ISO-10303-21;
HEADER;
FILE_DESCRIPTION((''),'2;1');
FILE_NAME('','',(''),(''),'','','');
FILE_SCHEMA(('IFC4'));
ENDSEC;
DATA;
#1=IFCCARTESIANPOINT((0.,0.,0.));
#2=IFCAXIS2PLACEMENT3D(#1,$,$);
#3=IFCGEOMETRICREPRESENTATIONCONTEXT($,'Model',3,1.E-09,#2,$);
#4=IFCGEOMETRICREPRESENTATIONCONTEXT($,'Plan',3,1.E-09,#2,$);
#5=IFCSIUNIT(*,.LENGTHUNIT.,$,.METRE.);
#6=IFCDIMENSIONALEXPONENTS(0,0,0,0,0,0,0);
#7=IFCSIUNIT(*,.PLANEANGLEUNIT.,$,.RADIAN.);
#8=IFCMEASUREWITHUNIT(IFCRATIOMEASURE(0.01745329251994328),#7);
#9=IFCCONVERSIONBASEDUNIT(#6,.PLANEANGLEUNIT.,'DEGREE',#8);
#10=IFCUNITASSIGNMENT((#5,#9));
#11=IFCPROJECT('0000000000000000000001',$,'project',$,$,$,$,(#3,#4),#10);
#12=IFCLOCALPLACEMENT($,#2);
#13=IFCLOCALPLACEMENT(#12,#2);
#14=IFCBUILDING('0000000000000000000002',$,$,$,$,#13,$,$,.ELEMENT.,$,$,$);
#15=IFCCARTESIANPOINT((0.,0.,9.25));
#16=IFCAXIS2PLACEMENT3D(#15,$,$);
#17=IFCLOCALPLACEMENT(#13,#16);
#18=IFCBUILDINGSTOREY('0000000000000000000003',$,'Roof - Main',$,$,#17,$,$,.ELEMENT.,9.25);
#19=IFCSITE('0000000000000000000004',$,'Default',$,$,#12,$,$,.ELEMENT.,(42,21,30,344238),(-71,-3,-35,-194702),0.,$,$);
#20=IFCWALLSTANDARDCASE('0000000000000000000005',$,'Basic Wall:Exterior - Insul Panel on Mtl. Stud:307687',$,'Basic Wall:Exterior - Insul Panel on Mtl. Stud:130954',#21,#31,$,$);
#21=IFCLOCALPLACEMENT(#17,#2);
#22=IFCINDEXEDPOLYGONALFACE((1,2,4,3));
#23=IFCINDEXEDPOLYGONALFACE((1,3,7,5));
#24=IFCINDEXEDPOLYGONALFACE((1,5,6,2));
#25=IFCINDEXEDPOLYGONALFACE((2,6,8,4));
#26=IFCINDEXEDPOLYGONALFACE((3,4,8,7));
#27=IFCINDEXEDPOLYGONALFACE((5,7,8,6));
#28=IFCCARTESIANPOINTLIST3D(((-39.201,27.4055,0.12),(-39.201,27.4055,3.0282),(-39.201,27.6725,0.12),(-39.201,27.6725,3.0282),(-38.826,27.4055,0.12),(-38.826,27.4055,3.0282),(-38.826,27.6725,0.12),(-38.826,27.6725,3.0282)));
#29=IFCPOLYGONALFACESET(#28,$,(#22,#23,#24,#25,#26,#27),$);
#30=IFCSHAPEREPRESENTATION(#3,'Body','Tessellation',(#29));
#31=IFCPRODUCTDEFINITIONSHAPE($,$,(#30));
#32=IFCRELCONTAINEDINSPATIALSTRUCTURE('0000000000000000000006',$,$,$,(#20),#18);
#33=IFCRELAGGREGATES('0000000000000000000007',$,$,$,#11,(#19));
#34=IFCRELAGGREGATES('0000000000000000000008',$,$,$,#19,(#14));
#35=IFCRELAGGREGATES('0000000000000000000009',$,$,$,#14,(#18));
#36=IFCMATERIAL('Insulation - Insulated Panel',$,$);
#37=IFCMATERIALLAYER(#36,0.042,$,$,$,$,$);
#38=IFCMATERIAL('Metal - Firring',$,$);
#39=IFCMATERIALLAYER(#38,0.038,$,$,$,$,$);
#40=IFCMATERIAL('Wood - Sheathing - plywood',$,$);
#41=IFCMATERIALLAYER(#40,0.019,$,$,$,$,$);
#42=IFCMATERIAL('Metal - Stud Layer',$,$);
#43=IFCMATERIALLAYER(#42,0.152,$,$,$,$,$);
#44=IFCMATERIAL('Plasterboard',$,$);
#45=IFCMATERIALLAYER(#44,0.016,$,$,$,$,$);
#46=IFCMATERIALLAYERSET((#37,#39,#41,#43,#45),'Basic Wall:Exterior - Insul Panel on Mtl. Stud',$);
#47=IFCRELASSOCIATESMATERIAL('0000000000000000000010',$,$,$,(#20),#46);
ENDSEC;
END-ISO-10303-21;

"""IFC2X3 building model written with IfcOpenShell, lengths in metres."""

from ifc_helpers import new_model, entity, si_unit, converted_unit, frame, frame_2d, origin, place, context, project, spatial, rectangle, extrude, material, layer, layer_set, layer_usage, element, save


model = new_model("IFC2X3")

# Units and contexts
model_context = context("Model", 3, precision=1e-09, world=origin())
plan_context = context("Plan", 3, precision=1e-09, world=origin())
ifc_project = project(units=[si_unit("LENGTHUNIT", "METRE"), converted_unit("PLANEANGLEUNIT", "DEGREE", entity("IfcRatioMeasure", 0.01745329251994328), si_unit("PLANEANGLEUNIT", "RADIAN"), dimensions=[0, 0, 0, 0, 0, 0, 0])], contexts=[model_context, plan_context])

# Site, building, storey
site_placement = place(None, origin())
site = spatial("IfcSite", under=ifc_project, at=site_placement, Name="Default", CompositionType="ELEMENT", RefLatitude=(42, 21, 30, 344238), RefLongitude=(-71, -3, -35, -194702), RefElevation=0.0)
building_placement = place(site_placement, origin())
building = spatial("IfcBuilding", under=site, at=building_placement, CompositionType="ELEMENT")
storey_placement = place(building_placement, frame((0.0, 0.0, 9.25)))
storey = spatial("IfcBuildingStorey", under=building, at=storey_placement, Name="Roof - Main", CompositionType="ELEMENT", Elevation=9.25)

# Wall
ifc_material_1 = material(Name="Insulation - Insulated Panel")
ifc_layer_1 = layer(ifc_material_1, 0.042)
ifc_material_2 = material(Name="Metal - Firring")
ifc_layer_2 = layer(ifc_material_2, 0.038)
ifc_material_3 = material(Name="Wood - Sheathing - plywood")
ifc_layer_3 = layer(ifc_material_3, 0.019)
ifc_material_4 = material(Name="Metal - Stud Layer")
ifc_layer_4 = layer(ifc_material_4, 0.152)
ifc_material_5 = material(Name="Plasterboard")
ifc_layer_5 = layer(ifc_material_5, 0.016)
ifc_layer_set = layer_set([ifc_layer_1, ifc_layer_2, ifc_layer_3, ifc_layer_4, ifc_layer_5], Name="Basic Wall:Exterior - Insul Panel on Mtl. Stud")
ifc_layer_usage_1 = layer_usage(ifc_layer_set, "AXIS2", "POSITIVE", -0.1335)
wall_1_placement = place(storey_placement, frame((-39.201, 27.539, 0.12)))
element("IfcWallStandardCase", 1, at=wall_1_placement, inside=storey, material=ifc_layer_usage_1, Name="Basic Wall:Exterior - Insul Panel on Mtl. Stud:307687", ObjectType="Basic Wall:Exterior - Insul Panel on Mtl. Stud:130954", context=model_context, shape_type="SweptSolid", body=[
    extrude(rectangle(XDim=0.375, YDim=0.267, at=frame_2d((0.1875, 0.0), x_axis=(-1.0, 0.0))), origin(), (0.0, 0.0, 1.0), 2.9082),
])

save(model, "model.ifc")
